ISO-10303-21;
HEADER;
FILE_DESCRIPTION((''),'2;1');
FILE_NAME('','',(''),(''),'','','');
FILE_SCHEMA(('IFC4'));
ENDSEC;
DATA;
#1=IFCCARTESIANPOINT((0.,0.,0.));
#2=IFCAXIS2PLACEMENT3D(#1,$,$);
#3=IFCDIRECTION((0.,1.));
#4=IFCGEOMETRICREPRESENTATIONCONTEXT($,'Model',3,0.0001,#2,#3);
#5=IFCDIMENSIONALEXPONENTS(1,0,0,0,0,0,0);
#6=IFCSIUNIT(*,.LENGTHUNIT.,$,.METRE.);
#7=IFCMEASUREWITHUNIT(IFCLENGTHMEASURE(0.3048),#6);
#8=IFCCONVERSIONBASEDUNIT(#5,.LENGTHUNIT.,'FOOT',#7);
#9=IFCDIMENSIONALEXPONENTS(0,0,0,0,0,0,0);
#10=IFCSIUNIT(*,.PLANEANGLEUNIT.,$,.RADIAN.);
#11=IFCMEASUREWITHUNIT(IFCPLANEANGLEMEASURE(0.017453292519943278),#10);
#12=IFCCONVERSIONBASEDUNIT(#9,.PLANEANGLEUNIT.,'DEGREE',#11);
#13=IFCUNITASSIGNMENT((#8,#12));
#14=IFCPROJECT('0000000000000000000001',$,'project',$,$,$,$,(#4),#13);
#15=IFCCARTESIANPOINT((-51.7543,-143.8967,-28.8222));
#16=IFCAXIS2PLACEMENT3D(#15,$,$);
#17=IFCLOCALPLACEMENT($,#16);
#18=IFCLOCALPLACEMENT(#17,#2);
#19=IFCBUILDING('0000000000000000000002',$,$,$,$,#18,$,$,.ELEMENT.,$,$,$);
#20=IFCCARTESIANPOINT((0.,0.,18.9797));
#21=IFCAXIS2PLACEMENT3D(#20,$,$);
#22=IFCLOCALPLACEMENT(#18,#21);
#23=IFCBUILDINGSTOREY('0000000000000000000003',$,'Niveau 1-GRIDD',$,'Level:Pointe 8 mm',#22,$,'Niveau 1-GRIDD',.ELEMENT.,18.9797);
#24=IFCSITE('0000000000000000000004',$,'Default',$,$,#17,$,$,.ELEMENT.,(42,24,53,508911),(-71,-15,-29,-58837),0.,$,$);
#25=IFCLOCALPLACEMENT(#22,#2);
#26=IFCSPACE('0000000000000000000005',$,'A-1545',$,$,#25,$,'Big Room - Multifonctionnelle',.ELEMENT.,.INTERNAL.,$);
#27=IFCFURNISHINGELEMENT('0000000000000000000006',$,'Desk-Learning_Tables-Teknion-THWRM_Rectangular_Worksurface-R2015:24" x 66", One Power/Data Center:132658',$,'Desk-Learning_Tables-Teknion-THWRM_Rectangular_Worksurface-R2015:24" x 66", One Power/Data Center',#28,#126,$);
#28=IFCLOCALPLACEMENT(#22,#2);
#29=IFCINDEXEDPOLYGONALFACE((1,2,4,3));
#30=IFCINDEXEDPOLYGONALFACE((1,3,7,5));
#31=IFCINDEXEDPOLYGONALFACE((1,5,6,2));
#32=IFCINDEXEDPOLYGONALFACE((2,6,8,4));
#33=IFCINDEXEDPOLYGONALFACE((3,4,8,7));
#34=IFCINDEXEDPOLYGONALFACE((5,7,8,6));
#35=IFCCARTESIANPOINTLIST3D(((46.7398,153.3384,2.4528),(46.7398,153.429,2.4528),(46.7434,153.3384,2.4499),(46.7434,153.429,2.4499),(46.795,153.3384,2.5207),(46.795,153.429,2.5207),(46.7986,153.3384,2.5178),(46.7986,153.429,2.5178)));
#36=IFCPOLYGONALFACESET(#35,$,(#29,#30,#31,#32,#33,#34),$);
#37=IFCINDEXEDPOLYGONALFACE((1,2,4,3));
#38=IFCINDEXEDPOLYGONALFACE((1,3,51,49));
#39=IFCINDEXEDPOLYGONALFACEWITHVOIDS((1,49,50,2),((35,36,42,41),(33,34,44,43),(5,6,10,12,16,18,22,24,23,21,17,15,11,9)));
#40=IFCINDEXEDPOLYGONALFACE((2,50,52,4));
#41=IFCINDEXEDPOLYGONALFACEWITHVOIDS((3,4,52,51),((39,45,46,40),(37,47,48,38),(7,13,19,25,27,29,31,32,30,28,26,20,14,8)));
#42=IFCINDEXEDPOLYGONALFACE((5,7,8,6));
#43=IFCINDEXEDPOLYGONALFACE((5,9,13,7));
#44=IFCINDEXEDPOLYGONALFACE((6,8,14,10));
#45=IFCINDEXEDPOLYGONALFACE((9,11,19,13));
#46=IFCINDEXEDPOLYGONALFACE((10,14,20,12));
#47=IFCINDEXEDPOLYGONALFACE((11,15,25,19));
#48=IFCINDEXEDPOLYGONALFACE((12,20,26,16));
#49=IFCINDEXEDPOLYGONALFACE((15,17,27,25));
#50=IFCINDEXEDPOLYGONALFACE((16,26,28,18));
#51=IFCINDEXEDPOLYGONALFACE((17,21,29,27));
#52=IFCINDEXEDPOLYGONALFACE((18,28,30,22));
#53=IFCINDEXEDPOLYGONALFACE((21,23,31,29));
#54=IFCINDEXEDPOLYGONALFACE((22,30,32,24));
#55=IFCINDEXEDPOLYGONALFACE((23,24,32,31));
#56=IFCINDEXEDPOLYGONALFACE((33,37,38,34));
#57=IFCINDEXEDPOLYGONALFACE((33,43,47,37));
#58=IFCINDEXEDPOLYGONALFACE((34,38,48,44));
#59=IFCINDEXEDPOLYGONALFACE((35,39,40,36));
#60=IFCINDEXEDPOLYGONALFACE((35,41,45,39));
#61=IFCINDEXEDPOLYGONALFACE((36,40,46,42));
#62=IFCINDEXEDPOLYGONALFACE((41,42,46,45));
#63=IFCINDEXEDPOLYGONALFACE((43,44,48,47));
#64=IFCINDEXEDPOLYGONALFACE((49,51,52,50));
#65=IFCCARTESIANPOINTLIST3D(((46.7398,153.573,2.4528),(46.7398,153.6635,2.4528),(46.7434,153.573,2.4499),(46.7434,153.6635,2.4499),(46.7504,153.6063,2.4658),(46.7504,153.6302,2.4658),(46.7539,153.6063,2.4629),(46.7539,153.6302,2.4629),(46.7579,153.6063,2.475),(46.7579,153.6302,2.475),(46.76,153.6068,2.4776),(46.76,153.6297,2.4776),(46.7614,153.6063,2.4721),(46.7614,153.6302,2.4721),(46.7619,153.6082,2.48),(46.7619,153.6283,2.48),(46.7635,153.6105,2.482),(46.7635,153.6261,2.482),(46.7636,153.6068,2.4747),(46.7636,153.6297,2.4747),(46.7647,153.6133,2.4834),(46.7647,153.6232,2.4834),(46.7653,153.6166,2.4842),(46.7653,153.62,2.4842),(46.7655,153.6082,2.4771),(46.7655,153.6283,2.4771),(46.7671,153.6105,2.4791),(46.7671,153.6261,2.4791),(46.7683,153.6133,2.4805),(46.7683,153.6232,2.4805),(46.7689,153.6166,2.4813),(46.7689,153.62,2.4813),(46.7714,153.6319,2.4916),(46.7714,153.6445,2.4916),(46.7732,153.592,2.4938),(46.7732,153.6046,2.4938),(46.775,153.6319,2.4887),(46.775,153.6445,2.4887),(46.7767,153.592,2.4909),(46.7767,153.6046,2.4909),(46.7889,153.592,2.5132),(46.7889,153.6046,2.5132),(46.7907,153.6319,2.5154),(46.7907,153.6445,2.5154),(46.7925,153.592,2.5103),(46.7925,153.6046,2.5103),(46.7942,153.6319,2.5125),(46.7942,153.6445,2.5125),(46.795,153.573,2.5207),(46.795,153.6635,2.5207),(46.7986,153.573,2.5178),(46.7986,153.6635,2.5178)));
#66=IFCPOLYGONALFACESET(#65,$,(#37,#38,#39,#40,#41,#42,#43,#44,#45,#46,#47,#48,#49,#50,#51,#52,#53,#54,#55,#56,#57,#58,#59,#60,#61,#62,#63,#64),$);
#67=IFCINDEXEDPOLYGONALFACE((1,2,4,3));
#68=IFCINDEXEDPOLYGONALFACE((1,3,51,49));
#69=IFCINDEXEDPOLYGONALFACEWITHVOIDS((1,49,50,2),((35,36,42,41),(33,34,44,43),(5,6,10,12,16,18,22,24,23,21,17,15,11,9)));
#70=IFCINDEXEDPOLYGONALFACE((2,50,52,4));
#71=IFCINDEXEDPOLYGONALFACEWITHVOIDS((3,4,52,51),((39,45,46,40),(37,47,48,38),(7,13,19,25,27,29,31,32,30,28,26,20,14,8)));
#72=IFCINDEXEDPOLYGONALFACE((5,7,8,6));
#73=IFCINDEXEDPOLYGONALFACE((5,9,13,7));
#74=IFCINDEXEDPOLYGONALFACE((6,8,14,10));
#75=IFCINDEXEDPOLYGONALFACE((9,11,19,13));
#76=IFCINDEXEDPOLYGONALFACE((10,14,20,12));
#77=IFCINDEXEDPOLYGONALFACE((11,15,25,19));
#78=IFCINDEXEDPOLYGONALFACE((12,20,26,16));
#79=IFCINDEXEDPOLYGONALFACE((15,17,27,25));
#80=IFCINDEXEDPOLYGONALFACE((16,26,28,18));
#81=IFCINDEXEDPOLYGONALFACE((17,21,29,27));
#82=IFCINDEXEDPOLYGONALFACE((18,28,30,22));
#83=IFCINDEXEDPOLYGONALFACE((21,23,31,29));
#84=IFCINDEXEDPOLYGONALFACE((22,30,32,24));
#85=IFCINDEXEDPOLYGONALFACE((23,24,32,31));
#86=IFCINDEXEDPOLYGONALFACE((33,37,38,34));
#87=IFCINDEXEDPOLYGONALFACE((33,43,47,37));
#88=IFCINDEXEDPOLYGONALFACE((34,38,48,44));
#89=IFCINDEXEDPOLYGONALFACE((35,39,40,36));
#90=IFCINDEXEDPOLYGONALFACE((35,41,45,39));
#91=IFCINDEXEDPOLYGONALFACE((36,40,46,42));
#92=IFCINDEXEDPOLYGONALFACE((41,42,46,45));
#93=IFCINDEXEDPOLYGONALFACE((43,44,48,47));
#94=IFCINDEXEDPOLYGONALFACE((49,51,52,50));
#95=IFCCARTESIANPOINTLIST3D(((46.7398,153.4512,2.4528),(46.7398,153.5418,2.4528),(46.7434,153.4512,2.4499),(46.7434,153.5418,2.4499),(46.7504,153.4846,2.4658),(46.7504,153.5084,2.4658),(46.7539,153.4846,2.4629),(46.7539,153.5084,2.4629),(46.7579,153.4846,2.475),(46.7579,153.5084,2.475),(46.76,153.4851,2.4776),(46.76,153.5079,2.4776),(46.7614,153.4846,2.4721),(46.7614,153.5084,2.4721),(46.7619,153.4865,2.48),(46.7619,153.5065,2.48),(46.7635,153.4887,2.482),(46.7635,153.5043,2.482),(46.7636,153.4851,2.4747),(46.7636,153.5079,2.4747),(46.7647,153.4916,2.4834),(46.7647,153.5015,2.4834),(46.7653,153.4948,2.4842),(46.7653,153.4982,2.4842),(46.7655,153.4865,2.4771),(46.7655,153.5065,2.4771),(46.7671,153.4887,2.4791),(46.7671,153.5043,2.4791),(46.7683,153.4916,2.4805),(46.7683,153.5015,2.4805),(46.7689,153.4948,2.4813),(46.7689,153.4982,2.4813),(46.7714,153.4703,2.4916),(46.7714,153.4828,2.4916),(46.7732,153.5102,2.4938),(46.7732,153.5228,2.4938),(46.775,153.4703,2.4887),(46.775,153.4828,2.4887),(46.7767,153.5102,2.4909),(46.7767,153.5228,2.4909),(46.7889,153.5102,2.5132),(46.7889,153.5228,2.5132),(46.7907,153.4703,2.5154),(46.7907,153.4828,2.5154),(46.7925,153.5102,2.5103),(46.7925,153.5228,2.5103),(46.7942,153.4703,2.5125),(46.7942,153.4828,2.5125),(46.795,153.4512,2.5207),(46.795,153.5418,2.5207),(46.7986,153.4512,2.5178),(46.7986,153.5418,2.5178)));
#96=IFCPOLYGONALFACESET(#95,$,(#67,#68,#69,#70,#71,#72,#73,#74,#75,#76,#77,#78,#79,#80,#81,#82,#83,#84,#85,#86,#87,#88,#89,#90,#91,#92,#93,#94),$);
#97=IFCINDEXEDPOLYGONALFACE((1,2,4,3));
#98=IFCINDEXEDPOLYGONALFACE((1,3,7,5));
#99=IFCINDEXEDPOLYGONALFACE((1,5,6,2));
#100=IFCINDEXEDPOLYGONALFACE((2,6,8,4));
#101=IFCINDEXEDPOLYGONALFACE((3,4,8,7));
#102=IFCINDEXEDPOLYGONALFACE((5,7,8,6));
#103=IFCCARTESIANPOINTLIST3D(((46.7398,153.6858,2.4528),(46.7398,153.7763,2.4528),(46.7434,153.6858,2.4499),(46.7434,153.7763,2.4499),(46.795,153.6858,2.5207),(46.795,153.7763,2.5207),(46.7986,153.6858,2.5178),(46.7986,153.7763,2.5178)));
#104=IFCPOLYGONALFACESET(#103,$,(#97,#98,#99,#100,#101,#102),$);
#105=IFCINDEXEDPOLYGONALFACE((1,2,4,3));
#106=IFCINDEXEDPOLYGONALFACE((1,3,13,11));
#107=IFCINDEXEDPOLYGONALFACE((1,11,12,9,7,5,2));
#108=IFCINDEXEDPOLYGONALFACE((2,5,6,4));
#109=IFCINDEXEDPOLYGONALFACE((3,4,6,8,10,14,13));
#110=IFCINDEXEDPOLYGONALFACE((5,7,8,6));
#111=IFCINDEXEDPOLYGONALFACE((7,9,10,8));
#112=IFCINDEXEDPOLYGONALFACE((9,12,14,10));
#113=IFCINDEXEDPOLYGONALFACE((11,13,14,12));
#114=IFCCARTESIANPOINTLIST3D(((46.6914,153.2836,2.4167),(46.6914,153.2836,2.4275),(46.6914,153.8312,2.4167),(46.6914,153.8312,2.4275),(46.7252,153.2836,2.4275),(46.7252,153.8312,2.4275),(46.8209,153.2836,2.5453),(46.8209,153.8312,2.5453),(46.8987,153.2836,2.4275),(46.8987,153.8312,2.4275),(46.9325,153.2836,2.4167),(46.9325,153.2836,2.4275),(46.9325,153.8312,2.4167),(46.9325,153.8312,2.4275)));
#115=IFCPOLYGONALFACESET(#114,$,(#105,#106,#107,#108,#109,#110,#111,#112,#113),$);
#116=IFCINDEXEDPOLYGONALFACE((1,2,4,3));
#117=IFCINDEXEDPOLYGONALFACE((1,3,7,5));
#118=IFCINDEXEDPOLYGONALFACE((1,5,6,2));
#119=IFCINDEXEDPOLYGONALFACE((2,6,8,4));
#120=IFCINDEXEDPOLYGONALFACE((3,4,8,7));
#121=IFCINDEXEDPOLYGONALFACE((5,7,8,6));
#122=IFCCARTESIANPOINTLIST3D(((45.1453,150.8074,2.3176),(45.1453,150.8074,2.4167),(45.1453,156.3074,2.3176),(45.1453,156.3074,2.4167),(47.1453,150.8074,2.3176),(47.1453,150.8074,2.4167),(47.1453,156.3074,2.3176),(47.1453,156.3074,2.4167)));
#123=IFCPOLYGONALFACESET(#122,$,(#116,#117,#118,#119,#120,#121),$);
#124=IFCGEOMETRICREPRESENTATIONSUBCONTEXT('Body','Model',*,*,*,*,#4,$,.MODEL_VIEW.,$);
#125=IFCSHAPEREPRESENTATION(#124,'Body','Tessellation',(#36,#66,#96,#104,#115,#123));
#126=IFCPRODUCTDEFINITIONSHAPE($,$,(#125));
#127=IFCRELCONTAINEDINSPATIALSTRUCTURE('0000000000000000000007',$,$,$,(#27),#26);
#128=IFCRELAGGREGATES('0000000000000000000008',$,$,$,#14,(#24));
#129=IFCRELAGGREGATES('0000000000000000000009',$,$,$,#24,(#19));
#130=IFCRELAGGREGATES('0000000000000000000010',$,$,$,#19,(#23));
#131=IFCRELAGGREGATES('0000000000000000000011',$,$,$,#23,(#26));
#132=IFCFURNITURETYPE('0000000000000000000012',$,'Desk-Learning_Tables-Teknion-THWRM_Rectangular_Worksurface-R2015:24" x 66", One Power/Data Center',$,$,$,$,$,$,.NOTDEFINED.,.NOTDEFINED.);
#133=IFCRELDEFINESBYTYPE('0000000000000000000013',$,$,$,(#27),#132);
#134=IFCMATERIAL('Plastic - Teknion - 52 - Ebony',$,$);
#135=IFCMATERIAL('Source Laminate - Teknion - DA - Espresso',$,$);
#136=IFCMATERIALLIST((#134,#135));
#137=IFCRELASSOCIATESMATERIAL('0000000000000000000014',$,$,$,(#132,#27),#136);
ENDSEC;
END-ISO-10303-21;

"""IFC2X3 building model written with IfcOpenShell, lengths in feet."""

from ifc_helpers import new_model, entity, si_unit, converted_unit, direction, frame, frame_2d, origin, place, context, subcontext, project, spatial, polyline, circle_curve, parameter, trimmed, segment, composite_curve, rectangle, outline, extrude, source, transform, mapped, material, material_list, type_object, type_shapes, element, save


model = new_model("IFC2X3")

# Units and contexts
model_context = context("Model", 3, precision=0.0001, world=origin(), true_north=direction((0.0, 1.0)))
body_context = subcontext(model_context, "Body", "Model", "MODEL_VIEW")
ifc_project = project(units=[converted_unit("LENGTHUNIT", "FOOT", entity("IfcLengthMeasure", 0.3048), si_unit("LENGTHUNIT", "METRE"), dimensions=[1, 0, 0, 0, 0, 0, 0]), converted_unit("PLANEANGLEUNIT", "DEGREE", entity("IfcPlaneAngleMeasure", 0.017453292519943278), si_unit("PLANEANGLEUNIT", "RADIAN"), dimensions=[0, 0, 0, 0, 0, 0, 0])], contexts=[model_context])

# Site, building, storey
site_placement = place(None, frame((-51.7543, -143.8967, -28.8222)))
site = spatial("IfcSite", under=ifc_project, at=site_placement, Name="Default", CompositionType="ELEMENT", RefLatitude=(42, 24, 53, 508911), RefLongitude=(-71, -15, -29, -58837), RefElevation=0.0)
building_placement = place(site_placement, origin())
building = spatial("IfcBuilding", under=site, at=building_placement, CompositionType="ELEMENT")
storey_placement = place(building_placement, frame((0.0, 0.0, 18.9797)))
storey = spatial("IfcBuildingStorey", under=building, at=storey_placement, Name="Niveau 1-GRIDD", ObjectType="Level:Pointe 8 mm", LongName="Niveau 1-GRIDD", CompositionType="ELEMENT", Elevation=18.9797)

# Shared definitions
space_1_placement = place(storey_placement, origin())
space_1 = spatial("IfcSpace", under=storey, at=space_1_placement, Name="A-1545", LongName="Big Room - Multifonctionnelle", CompositionType="ELEMENT", InteriorOrExteriorSpace="INTERNAL")

# Furnishing element
ifc_material_1 = material(Name="Plastic - Teknion - 52 - Ebony")
ifc_material_2 = material(Name="Source Laminate - Teknion - DA - Espresso")
ifc_material_list_1 = material_list([ifc_material_1, ifc_material_2])
furniture_type_1 = type_object("IfcFurnitureType", Name="Desk-Learning_Tables-Teknion-THWRM_Rectangular_Worksurface-R2015:24\" x 66\", One Power/Data Center", AssemblyPlace="NOTDEFINED", material=ifc_material_list_1)
shared_shape_1 = source(origin(), body_context, "Body", "SweptSolid", [
    extrude(rectangle(XDim=0.0875, YDim=0.0046, at=frame_2d((0.0, 0.0), x_axis=(0.0, 1.0))), frame((0.1284, 0.6239, 2.4853), z_axis=(1.0, 0.0, 0.0), x_axis=(0.0, 0.776046, -0.630676)), (0.0, 0.0, 1.0), 0.0906),
    extrude(outline(polyline([(-0.0453, -0.0438), (0.0453, -0.0438), (0.0453, 0.0438), (-0.0453, 0.0438), (-0.0453, -0.0438)]), holes=[polyline([(-0.0262, -0.0063), (-0.0137, -0.0063), (-0.0137, -0.0369), (-0.0262, -0.0369), (-0.0262, -0.0063)]), polyline([(0.0137, -0.0341), (0.0137, -0.0091), (0.0262, -0.0091), (0.0262, -0.0341), (0.0137, -0.0341)]), composite_curve([segment(polyline([(-0.0119, 0.027), (0.0119, 0.027)]), True, "CONTINUOUS"), segment(polyline([(0.0119, 0.027), (0.0119, 0.0151)]), True, "CONTINUOUS"), segment(trimmed(circle_curve(frame_2d((0.0, 0.0151), x_axis=(0.0, -1.0)), 0.0119), [parameter(270.0)], [parameter(90.0)], True, "PARAMETER"), False, "CONTINUOUS"), segment(polyline([(-0.0119, 0.0151), (-0.0119, 0.027)]), True, "CONTINUOUS")], self_intersect=False)]), frame((-0.0609, 0.6221, 2.4867), z_axis=(0.0, 0.776046, -0.630676), x_axis=(1.0, 0.0, 0.0)), (0.0, 0.0, 1.0), 0.0046),
    extrude(outline(polyline([(-0.0438, -0.0453), (0.0438, -0.0453), (0.0438, 0.0453), (-0.0438, 0.0453), (-0.0438, -0.0453)]), holes=[polyline([(-0.0063, -0.0262), (-0.0369, -0.0262), (-0.0369, -0.0137), (-0.0063, -0.0137), (-0.0063, -0.0262)]), polyline([(-0.0341, 0.0137), (-0.0341, 0.0262), (-0.0091, 0.0262), (-0.0091, 0.0137), (-0.0341, 0.0137)]), composite_curve([segment(polyline([(0.027, -0.0119), (0.0151, -0.0119)]), True, "CONTINUOUS"), segment(trimmed(circle_curve(frame_2d((0.0151, 0.0), x_axis=(-1.0, 0.0)), 0.0119), [parameter(270.0)], [parameter(90.0)], True, "PARAMETER"), False, "CONTINUOUS"), segment(polyline([(0.0151, 0.0119), (0.027, 0.0119)]), True, "CONTINUOUS"), segment(polyline([(0.027, 0.0119), (0.027, -0.0119)]), True, "CONTINUOUS")], self_intersect=False)]), frame((0.0609, 0.6221, 2.4867), z_axis=(0.0, 0.776046, -0.630676), x_axis=(0.0, -0.630676, -0.776046)), (0.0, 0.0, 1.0), 0.0046),
    extrude(rectangle(XDim=0.0875, YDim=0.0046, at=frame_2d((0.0, 0.0), x_axis=(0.0, 1.0))), frame((-0.219, 0.6239, 2.4853), z_axis=(1.0, 0.0, 0.0), x_axis=(0.0, 0.776046, -0.630676)), (0.0, 0.0, 1.0), 0.0906),
    extrude(outline(polyline([(-0.0586, -0.0638), (0.0826, -0.0638), (0.0371, 0.0811), (0.0557, 0.1093), (0.0467, 0.1152), (-0.0862, -0.086), (-0.0772, -0.092), (-0.0586, -0.0638)])), frame((-0.2738, 0.6679, 2.4412), z_axis=(1.0, 0.0, 0.0), x_axis=(0.0, -0.551103, 0.834437)), (0.0, 0.0, 1.0), 0.5475),
    extrude(rectangle(XDim=5.5, YDim=2.0, at=frame_2d((0.0, 0.0), x_axis=(1.0, 0.0))), frame((0.0, 0.0, 2.3176), z_axis=(0.0, 0.0, 1.0), x_axis=(-1.0, 0.0, 0.0)), (0.0, 0.0, 1.0), 0.0991),
])
type_shapes(furniture_type_1, [shared_shape_1])
for number, where, z_axis, x_axis, name in (
    (1, (46.1453, 153.5574, 0.0), (0.0, 0.0, 1.0), (0.0, -1.0, 0.0), "Desk-Learning_Tables-Teknion-THWRM_Rectangular_Worksurface-R2015:24\" x 66\", One Power/Data Center:132658"),
):
    element("IfcFurnishingElement", number, at=place(space_1_placement, frame(where, z_axis=z_axis, x_axis=x_axis)), inside=space_1, type_object=furniture_type_1, material=ifc_material_list_1, Name=name, ObjectType="Desk-Learning_Tables-Teknion-THWRM_Rectangular_Worksurface-R2015:24\" x 66\", One Power/Data Center", context=body_context, shape_type="MappedRepresentation", body=[
        mapped(shared_shape_1, transform((0.0, 0.0, 0.0), scale=1.0)),
    ])

save(model, "model.ifc")
